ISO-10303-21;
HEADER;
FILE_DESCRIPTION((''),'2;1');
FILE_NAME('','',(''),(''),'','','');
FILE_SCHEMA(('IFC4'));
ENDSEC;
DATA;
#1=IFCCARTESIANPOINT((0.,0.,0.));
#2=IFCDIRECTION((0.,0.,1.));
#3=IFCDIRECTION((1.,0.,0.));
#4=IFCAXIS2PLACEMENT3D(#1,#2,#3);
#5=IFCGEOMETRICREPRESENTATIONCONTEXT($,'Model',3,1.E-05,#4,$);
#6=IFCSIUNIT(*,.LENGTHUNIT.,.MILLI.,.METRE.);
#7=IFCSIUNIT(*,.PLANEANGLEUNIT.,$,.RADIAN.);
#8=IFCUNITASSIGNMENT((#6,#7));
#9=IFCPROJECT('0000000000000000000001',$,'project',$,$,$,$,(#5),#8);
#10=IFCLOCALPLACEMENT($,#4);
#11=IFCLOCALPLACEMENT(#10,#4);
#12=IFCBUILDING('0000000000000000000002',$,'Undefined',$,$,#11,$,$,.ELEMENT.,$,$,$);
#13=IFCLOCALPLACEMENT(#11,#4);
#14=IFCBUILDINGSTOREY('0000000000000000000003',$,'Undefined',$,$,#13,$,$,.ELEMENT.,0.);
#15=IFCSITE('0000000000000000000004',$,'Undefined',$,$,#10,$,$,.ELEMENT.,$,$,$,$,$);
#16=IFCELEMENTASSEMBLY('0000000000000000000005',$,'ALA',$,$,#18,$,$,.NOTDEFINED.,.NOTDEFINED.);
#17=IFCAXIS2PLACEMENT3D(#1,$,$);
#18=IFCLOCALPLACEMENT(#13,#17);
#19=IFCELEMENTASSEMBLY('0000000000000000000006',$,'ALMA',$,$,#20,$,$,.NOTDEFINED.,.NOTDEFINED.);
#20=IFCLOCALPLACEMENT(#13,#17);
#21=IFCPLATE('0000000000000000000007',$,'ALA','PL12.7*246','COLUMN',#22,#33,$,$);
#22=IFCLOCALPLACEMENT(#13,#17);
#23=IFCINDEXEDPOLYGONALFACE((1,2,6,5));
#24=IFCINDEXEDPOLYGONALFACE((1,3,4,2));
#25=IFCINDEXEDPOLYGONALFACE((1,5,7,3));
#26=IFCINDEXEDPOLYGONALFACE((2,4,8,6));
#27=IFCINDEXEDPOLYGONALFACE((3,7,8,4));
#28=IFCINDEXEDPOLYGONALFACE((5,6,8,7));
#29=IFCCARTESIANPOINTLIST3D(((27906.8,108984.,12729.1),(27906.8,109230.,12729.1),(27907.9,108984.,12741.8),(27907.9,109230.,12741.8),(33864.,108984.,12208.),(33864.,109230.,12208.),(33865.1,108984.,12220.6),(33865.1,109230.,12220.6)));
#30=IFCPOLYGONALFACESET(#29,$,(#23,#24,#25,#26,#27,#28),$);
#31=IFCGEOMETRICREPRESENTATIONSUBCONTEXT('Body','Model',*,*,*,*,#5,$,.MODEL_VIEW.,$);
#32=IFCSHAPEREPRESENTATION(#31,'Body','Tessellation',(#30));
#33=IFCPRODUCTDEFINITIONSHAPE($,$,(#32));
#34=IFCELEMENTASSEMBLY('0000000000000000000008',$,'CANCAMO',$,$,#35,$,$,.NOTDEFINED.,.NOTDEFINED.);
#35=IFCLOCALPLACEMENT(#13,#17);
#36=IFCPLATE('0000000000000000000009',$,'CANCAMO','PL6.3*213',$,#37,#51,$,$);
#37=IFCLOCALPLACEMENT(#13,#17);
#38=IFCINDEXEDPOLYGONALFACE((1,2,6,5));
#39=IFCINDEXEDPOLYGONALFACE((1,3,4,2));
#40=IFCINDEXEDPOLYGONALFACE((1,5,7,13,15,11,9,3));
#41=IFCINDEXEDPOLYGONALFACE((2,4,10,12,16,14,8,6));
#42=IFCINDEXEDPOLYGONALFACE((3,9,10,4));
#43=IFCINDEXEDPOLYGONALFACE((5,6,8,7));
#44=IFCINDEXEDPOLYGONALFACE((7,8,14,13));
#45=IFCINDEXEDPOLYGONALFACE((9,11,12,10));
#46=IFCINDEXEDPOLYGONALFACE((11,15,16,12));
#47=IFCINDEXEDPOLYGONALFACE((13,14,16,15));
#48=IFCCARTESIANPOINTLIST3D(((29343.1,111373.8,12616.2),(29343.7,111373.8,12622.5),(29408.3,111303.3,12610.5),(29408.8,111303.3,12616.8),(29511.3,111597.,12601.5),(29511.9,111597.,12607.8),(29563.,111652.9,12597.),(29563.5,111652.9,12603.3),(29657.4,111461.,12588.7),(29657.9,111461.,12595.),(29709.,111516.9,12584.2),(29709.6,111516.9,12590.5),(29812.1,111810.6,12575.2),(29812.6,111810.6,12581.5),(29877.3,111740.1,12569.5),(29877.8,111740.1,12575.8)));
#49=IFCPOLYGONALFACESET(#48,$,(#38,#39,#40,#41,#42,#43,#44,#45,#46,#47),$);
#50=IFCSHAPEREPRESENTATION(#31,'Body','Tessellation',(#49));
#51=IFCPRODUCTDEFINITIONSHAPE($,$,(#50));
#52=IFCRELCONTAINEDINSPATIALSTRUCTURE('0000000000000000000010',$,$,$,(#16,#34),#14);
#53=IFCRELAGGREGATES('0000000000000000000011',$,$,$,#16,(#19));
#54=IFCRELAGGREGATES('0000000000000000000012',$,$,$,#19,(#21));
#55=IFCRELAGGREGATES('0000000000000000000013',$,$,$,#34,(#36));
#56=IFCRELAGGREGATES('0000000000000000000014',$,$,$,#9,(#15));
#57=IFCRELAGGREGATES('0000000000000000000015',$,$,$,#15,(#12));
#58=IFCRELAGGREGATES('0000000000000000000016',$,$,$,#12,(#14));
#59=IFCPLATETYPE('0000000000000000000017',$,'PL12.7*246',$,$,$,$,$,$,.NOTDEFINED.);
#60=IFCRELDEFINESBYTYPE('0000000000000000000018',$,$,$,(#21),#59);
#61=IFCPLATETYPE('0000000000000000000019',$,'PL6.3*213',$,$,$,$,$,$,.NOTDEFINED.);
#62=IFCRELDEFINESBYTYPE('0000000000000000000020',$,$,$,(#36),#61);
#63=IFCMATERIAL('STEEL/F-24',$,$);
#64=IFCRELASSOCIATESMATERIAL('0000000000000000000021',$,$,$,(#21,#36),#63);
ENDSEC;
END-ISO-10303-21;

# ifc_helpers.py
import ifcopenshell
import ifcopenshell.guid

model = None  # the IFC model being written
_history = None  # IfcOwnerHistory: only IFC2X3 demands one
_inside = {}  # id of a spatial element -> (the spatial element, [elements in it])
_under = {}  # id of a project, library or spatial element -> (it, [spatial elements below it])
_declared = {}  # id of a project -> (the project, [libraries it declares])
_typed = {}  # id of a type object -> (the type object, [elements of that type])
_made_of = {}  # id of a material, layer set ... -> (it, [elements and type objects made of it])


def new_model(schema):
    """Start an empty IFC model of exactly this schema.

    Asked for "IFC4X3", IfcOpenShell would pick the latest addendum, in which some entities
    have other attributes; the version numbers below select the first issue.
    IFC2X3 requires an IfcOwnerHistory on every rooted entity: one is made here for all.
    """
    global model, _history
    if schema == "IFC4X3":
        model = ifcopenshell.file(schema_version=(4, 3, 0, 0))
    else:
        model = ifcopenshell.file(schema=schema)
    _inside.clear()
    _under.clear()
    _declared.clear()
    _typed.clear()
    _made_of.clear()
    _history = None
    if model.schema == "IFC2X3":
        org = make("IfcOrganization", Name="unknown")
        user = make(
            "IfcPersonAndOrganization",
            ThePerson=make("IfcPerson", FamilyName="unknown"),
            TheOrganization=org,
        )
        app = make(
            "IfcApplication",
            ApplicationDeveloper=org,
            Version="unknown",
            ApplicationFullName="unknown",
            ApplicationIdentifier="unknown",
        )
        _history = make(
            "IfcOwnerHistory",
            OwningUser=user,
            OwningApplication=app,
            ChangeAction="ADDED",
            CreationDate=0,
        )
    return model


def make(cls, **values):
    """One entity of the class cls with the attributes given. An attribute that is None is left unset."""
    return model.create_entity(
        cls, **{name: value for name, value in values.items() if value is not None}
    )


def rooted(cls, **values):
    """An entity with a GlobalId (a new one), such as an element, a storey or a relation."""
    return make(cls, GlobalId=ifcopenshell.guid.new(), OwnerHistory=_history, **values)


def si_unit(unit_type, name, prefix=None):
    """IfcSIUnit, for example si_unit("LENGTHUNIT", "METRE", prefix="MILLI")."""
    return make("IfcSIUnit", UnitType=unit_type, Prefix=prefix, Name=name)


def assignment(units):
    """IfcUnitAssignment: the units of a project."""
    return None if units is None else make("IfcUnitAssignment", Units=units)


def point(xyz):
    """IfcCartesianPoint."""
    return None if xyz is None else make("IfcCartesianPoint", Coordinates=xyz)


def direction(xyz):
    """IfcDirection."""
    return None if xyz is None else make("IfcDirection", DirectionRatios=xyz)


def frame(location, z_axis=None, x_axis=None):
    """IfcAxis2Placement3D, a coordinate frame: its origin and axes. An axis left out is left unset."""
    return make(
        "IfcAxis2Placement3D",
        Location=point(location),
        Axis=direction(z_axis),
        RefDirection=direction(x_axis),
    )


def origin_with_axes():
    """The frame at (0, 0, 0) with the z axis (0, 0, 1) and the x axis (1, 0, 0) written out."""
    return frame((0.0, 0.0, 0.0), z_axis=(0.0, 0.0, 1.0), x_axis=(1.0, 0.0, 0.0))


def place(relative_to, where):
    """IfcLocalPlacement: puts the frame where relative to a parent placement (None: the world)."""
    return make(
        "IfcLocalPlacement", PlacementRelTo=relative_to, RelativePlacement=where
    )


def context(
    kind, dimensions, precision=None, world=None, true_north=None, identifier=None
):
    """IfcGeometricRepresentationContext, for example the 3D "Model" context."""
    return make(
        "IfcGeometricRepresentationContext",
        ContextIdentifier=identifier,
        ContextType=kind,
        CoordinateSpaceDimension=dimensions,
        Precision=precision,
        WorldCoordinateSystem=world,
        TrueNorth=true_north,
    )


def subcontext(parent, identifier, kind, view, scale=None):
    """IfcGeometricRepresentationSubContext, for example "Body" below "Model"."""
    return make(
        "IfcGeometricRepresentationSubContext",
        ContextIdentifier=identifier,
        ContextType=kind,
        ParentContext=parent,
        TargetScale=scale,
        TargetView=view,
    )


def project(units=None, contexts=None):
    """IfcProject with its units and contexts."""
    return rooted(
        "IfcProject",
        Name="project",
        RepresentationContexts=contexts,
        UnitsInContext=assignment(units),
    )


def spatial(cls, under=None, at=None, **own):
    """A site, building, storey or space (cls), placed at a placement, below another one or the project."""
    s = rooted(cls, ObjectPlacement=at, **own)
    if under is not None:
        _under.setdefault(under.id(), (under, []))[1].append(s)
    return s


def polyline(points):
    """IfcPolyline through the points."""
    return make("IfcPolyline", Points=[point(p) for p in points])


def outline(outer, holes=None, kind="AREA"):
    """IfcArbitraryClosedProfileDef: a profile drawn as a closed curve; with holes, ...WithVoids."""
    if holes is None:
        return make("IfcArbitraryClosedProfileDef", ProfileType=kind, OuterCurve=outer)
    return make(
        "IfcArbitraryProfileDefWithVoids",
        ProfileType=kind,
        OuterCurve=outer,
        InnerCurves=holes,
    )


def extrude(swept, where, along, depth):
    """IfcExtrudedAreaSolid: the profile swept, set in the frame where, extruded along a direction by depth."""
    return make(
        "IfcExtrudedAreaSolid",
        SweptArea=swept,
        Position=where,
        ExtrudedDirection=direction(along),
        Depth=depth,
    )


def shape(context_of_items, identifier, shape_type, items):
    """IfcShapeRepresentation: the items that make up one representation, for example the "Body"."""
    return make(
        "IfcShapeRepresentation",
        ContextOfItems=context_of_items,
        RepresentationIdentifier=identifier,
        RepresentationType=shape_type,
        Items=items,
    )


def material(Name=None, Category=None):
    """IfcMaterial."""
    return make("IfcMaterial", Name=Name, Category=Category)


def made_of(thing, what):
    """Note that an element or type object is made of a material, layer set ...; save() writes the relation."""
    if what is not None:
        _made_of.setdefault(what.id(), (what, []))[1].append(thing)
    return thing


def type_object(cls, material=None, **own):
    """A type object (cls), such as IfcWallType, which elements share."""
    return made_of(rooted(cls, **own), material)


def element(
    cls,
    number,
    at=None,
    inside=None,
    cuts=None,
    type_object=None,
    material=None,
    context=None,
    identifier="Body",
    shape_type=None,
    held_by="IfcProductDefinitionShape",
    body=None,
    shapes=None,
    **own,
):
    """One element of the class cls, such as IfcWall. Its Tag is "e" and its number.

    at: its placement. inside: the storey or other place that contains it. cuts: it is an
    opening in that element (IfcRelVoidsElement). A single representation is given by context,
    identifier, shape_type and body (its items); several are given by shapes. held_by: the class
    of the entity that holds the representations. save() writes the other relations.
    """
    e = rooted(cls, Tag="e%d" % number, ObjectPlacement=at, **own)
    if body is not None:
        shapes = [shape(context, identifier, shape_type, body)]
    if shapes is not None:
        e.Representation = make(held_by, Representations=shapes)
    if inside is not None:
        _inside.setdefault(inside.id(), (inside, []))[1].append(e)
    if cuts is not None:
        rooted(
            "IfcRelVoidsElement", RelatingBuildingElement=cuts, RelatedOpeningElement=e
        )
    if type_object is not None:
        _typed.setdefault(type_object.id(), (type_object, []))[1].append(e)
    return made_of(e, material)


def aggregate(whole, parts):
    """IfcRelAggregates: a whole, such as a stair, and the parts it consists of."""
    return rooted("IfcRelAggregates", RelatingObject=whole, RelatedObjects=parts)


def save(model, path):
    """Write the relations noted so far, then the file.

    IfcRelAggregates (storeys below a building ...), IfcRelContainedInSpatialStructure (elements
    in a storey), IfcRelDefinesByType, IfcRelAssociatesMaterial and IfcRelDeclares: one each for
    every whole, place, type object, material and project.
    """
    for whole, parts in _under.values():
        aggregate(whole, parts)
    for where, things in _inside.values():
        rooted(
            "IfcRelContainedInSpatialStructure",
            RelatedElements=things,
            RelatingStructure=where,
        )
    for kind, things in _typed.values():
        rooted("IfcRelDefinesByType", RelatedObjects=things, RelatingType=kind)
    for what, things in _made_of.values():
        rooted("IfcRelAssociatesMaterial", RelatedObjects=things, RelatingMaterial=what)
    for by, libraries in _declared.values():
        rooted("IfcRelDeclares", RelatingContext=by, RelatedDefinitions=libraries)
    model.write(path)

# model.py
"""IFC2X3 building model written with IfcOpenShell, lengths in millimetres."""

from ifc_helpers import new_model, si_unit, frame, origin_with_axes, place, context, subcontext, project, spatial, polyline, outline, extrude, material, type_object, element, aggregate, save


model = new_model("IFC2X3")

# Units and contexts
model_context = context("Model", 3, precision=1e-05, world=origin_with_axes())
body_context = subcontext(model_context, "Body", "Model", "MODEL_VIEW")
ifc_project = project(units=[si_unit("LENGTHUNIT", "METRE", prefix="MILLI"), si_unit("PLANEANGLEUNIT", "RADIAN")], contexts=[model_context])

# Site, building, storey
site_placement = place(None, origin_with_axes())
site = spatial("IfcSite", under=ifc_project, at=site_placement, Name="Undefined", CompositionType="ELEMENT")
building_placement = place(site_placement, origin_with_axes())
building = spatial("IfcBuilding", under=site, at=building_placement, Name="Undefined", CompositionType="ELEMENT")
storey_placement = place(building_placement, origin_with_axes())
storey = spatial("IfcBuildingStorey", under=building, at=storey_placement, Name="Undefined", CompositionType="ELEMENT", Elevation=0.0)

# Shared definitions
ifc_material_1 = material(Name="STEEL/F-24")

# Element assemblies, plate
assembly_1_placement = place(storey_placement, origin_with_axes())
assembly_1 = element("IfcElementAssembly", 1, at=assembly_1_placement, inside=storey, Name="ALA", AssemblyPlace="NOTDEFINED", PredefinedType="NOTDEFINED")
assembly_2_placement = place(assembly_1_placement, origin_with_axes())
assembly_2 = element("IfcElementAssembly", 2, at=assembly_2_placement, Name="ALMA", AssemblyPlace="NOTDEFINED", PredefinedType="NOTDEFINED")
aggregate(assembly_1, [assembly_2])
plate_type_1 = type_object("IfcPlateType", Name="PL12.7*246", PredefinedType="NOTDEFINED")
plate_1_placement = place(assembly_2_placement, frame((27907.4, 109107.0, 12735.5), z_axis=(-0.087155, 0.0, -0.996195), x_axis=(0.996195, 0.0, -0.087155)))
plate_1 = element("IfcPlate", 3, at=plate_1_placement, type_object=plate_type_1, material=ifc_material_1, Name="ALA", Description="PL12.7*246", ObjectType="COLUMN", context=body_context, shape_type="SweptSolid", body=[
    extrude(outline(polyline([(0.0, -123.0), (0.0, 123.0), (5980.0, 123.0), (5980.0, -123.0), (0.0, -123.0)])), frame((0.0, 0.0, -6.3), z_axis=(0.0, 0.0, 1.0), x_axis=(1.0, 0.0, 0.0)), (0.0, 0.0, 1.0), 12.7),
])
aggregate(assembly_2, [plate_1])

# Element assembly, plate
assembly_3_placement = place(storey_placement, origin_with_axes())
assembly_3 = element("IfcElementAssembly", 4, at=assembly_3_placement, inside=storey, Name="CANCAMO", AssemblyPlace="NOTDEFINED", PredefinedType="NOTDEFINED")
plate_type_2 = type_object("IfcPlateType", Name="PL6.3*213", PredefinedType="NOTDEFINED")
plate_2_placement = place(assembly_3_placement, frame((29657.7, 111461.0, 12591.9), z_axis=(-0.087155, 0.0, -0.996195), x_axis=(-0.842559, -0.533536, 0.073714)))
plate_2 = element("IfcPlate", 5, at=plate_2_placement, type_object=plate_type_2, material=ifc_material_1, Name="CANCAMO", Description="PL6.3*213", context=body_context, shape_type="SweptSolid", body=[
    extrude(outline(polyline([(0.0, 0.0), (295.6, 0.0), (313.4, 94.6), (51.4, 193.3), (-22.2, 212.9), (-317.9, 212.9), (-335.6, 118.3), (-73.6, 19.6), (0.0, 0.0)])), frame((0.0, 0.0, -3.1), z_axis=(0.0, 0.0, 1.0), x_axis=(1.0, 0.0, 0.0)), (0.0, 0.0, 1.0), 6.3),
])
aggregate(assembly_3, [plate_2])

save(model, "model.ifc")
